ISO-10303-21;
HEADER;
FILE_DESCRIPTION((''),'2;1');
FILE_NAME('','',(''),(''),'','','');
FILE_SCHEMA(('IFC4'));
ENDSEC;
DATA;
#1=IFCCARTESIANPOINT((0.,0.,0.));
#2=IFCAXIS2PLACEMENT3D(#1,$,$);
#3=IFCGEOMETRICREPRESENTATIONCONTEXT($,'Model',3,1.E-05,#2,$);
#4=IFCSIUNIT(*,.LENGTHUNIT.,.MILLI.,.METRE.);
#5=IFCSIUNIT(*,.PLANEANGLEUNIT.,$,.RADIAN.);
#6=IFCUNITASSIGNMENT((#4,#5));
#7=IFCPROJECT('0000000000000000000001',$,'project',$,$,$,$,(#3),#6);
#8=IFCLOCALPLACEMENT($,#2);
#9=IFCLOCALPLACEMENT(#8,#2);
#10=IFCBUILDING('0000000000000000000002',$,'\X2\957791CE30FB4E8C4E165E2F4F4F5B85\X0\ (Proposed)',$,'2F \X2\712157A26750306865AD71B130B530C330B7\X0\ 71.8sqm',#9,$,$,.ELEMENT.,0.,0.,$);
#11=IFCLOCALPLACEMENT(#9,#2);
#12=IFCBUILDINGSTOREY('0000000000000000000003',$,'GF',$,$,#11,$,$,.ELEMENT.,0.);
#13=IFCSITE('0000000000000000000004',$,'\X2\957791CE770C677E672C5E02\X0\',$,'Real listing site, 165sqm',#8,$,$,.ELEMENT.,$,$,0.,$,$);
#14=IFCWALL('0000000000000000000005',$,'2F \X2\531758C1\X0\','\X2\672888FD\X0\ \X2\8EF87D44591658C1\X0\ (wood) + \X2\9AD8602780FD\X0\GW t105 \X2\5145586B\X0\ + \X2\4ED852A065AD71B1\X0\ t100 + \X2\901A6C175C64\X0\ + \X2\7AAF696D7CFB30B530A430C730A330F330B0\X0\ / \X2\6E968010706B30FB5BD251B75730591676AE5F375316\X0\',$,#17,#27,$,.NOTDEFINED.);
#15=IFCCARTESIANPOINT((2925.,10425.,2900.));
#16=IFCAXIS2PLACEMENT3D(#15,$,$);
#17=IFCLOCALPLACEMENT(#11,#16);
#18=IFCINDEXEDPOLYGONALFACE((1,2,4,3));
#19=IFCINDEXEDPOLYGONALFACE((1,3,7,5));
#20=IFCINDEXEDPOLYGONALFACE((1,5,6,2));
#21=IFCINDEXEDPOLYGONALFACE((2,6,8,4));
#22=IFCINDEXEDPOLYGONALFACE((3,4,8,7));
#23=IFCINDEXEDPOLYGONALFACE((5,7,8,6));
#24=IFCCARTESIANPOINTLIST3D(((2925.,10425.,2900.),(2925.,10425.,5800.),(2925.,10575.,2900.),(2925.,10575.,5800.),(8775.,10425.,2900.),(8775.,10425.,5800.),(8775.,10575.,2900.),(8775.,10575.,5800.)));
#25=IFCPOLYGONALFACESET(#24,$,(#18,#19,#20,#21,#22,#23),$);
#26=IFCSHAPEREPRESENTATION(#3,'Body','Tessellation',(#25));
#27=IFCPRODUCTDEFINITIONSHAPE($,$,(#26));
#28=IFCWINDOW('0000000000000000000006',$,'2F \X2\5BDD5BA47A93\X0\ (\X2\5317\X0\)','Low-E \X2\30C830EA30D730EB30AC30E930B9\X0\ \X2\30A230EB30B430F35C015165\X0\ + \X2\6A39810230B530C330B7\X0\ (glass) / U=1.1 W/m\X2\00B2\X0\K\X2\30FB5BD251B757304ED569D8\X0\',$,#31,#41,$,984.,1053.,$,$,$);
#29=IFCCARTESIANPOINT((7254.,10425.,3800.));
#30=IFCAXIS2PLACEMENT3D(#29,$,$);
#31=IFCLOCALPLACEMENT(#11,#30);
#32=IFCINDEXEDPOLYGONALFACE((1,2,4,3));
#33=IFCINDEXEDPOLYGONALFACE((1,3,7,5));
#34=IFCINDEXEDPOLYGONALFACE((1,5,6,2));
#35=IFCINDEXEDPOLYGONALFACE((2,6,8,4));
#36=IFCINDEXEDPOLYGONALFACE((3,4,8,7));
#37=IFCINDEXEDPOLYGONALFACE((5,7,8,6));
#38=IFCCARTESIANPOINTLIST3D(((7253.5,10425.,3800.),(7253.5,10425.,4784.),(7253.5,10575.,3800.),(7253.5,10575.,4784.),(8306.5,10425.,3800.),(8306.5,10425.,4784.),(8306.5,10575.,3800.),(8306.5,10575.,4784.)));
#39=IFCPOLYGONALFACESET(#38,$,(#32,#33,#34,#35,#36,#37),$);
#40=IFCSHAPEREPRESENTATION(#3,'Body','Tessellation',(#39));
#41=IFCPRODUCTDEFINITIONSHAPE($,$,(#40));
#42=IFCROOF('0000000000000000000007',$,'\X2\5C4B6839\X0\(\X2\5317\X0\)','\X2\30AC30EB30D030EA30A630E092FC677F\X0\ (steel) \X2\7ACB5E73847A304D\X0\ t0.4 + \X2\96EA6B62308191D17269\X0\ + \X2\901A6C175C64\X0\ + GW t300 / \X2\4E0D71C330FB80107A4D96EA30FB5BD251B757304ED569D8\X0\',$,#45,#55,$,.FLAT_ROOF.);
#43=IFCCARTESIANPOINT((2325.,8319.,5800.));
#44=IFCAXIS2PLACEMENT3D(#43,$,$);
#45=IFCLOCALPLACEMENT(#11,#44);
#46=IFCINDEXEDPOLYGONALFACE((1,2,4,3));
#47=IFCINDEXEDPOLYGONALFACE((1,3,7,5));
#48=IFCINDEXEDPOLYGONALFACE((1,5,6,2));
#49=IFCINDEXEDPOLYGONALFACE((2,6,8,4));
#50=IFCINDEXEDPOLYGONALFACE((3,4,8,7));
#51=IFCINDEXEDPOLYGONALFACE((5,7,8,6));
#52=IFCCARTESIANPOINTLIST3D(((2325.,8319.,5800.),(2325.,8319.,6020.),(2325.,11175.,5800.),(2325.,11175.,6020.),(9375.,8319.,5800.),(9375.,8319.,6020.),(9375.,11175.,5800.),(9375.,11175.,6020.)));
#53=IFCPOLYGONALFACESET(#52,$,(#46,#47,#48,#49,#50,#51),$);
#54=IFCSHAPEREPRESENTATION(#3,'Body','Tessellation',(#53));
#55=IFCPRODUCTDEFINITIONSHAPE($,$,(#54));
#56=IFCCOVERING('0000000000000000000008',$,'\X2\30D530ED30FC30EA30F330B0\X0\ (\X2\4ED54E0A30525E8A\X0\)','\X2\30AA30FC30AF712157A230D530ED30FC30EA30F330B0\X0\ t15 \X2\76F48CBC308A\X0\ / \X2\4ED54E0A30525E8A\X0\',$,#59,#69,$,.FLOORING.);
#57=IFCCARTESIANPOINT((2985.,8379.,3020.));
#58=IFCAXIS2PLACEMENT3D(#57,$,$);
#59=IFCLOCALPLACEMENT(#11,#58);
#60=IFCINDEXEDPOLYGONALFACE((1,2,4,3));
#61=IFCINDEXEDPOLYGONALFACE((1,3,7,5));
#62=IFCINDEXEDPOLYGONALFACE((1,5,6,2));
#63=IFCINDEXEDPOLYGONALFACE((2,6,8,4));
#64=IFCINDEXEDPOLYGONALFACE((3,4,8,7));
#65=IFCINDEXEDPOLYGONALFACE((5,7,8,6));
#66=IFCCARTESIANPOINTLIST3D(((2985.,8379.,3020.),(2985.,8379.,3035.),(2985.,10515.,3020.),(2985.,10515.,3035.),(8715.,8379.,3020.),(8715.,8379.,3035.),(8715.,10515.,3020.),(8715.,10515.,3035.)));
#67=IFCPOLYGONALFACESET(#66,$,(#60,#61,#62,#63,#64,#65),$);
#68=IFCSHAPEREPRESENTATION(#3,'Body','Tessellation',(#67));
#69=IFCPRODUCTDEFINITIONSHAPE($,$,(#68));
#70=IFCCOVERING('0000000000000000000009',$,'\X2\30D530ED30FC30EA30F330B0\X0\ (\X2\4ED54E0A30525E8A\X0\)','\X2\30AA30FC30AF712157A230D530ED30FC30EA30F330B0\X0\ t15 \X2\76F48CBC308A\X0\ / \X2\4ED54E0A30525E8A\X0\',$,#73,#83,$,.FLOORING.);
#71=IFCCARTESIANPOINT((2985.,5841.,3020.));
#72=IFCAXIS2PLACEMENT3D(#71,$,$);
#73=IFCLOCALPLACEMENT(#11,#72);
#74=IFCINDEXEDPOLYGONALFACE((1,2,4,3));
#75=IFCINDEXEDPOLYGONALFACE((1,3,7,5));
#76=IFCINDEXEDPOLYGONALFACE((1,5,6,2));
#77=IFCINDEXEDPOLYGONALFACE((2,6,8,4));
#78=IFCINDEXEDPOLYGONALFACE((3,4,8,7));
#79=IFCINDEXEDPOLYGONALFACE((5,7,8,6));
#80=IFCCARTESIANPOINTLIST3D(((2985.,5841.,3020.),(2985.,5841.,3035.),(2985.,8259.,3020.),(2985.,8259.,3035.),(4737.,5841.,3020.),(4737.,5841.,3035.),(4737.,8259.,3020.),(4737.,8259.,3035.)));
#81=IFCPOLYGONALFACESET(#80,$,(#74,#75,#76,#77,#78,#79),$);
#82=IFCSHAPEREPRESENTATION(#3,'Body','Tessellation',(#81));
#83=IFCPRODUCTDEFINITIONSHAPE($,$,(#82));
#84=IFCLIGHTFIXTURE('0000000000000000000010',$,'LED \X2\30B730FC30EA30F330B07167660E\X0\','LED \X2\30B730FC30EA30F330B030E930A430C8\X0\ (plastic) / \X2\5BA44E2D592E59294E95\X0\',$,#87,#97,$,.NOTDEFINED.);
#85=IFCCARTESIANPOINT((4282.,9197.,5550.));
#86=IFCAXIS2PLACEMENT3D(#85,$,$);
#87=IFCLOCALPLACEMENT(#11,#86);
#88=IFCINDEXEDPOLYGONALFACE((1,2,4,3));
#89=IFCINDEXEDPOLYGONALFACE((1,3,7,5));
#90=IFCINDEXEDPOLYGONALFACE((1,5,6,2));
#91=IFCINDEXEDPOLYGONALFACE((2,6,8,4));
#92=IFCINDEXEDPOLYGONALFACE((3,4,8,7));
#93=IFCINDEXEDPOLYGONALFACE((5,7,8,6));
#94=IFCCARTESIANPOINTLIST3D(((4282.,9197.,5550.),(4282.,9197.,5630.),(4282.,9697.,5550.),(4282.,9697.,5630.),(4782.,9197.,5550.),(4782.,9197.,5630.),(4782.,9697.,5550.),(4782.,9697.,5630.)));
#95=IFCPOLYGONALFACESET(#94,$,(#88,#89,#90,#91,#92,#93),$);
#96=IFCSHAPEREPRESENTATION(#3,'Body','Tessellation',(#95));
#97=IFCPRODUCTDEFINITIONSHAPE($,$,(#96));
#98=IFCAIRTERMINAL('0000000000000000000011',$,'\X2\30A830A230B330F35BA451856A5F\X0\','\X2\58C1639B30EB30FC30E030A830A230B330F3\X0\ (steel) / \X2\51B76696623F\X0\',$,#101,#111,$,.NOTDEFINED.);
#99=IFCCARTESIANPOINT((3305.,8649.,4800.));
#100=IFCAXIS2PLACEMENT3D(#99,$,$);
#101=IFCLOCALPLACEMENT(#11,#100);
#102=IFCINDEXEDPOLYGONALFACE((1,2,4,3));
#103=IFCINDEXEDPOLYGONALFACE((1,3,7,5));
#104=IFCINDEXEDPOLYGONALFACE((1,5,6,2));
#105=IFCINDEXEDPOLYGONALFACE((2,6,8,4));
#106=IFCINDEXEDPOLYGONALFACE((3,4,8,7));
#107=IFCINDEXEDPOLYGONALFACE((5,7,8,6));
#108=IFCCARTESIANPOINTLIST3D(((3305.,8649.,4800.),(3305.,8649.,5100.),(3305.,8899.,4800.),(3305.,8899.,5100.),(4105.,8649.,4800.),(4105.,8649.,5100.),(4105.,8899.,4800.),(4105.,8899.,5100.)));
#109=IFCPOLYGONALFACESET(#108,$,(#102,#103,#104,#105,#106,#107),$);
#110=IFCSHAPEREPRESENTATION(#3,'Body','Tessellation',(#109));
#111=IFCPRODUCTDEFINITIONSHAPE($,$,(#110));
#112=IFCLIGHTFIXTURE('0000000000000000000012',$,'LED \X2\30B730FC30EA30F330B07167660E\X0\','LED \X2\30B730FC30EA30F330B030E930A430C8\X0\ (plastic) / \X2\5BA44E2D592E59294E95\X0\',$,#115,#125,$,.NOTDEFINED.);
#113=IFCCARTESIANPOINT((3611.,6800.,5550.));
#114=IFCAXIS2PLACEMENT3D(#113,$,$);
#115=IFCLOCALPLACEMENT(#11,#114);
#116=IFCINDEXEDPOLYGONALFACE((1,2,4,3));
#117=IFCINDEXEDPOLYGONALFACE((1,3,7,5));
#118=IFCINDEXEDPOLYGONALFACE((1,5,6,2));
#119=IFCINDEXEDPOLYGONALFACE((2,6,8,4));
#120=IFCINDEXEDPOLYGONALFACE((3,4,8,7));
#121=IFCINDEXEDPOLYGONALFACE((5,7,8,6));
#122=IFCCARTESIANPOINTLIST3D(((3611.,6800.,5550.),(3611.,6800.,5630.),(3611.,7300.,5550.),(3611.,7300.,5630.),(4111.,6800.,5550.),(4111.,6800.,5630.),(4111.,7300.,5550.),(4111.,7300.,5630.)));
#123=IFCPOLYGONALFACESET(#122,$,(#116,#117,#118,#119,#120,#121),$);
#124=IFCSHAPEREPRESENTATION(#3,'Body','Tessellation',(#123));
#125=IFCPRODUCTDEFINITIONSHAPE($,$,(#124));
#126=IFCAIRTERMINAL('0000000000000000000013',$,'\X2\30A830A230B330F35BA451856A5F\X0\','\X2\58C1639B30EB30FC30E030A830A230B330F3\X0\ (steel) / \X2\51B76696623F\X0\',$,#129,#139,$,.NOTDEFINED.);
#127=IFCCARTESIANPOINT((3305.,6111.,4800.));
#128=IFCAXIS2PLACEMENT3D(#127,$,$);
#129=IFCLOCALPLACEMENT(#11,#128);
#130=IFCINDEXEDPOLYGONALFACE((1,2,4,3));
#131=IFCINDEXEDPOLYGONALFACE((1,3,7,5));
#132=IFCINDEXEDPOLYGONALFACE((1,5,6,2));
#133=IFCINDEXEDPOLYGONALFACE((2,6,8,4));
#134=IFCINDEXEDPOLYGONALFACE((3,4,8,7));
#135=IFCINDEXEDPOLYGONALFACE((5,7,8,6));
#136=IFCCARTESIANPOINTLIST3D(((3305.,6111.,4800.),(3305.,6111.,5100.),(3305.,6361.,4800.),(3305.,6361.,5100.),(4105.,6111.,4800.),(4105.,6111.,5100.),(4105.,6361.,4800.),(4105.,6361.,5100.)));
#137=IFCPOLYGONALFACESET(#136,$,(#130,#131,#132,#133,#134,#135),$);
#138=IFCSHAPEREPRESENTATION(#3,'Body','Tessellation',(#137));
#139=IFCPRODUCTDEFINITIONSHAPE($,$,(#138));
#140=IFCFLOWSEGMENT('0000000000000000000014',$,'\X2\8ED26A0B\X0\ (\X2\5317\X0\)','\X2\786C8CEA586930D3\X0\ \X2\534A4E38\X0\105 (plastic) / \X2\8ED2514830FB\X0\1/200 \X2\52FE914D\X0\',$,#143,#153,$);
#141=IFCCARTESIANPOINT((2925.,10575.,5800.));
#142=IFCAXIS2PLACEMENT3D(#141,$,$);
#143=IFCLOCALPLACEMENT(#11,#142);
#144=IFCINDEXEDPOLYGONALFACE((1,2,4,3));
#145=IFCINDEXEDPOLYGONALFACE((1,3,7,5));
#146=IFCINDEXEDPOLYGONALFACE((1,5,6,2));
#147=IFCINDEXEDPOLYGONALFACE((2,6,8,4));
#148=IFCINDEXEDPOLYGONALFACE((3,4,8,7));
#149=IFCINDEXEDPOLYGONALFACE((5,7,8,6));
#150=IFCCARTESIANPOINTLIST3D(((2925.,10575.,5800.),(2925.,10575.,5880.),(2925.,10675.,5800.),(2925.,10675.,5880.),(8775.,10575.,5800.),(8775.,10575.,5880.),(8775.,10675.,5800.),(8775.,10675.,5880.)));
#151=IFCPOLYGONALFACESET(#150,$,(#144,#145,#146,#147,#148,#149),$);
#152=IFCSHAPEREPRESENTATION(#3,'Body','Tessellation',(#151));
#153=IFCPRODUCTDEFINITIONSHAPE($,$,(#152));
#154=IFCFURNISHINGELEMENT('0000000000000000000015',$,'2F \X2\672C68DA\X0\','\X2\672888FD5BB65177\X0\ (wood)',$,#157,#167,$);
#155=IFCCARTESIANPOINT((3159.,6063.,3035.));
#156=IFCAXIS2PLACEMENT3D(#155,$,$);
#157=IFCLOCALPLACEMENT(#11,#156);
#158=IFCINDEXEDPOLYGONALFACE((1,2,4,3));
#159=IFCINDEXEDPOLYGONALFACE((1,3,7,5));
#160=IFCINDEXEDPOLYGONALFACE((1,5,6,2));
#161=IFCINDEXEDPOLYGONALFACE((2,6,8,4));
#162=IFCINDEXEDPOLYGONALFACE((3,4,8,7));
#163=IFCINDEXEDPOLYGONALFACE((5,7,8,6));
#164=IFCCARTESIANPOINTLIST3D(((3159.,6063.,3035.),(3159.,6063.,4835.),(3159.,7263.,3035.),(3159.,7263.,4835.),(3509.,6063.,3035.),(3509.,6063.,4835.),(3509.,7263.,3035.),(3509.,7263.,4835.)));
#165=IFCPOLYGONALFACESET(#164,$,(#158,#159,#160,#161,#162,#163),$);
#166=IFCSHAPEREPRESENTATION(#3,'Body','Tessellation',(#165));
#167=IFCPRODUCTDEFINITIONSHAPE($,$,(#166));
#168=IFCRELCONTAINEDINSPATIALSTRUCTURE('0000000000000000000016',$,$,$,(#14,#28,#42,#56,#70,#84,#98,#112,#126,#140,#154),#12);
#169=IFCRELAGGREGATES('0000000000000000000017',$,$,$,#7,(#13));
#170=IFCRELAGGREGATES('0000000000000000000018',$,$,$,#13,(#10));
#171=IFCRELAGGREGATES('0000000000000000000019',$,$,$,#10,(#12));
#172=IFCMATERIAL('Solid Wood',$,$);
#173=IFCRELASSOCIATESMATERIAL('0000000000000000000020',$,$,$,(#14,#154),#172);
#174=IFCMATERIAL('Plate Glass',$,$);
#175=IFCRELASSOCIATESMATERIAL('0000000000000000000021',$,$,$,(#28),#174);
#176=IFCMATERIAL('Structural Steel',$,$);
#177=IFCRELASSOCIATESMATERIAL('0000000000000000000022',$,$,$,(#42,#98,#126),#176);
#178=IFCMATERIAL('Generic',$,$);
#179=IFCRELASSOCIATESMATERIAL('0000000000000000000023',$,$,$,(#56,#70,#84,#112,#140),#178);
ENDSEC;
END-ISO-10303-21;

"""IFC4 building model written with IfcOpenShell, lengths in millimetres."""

from ifc_helpers import new_model, si_unit, frame, frame_2d, origin, place, context, project, spatial, rectangle, extrude, material, element, fill, save


model = new_model("IFC4")

# Units and contexts
model_context = context("Model", 3, precision=1e-05, world=origin())
ifc_project = project(units=[si_unit("LENGTHUNIT", "METRE", prefix="MILLI"), si_unit("PLANEANGLEUNIT", "RADIAN")], contexts=[model_context])

# Site, building, storey
site_placement = place(None, origin())
site = spatial("IfcSite", under=ifc_project, at=site_placement, Name="長野県松本市", ObjectType="Real listing site, 165sqm", CompositionType="ELEMENT", RefElevation=0.0)
building_placement = place(site_placement, origin())
building = spatial("IfcBuilding", under=site, at=building_placement, Name="長野・二世帯住宅 (Proposed)", ObjectType="2F 無垢材と断熱サッシ 71.8sqm", CompositionType="ELEMENT", ElevationOfRefHeight=0.0, ElevationOfTerrain=0.0)
storey_placement = place(building_placement, origin())
storey = spatial("IfcBuildingStorey", under=building, at=storey_placement, Name="GF", CompositionType="ELEMENT", Elevation=0.0)

# Shared definitions
ifc_material_1 = material(Name="Solid Wood")

# Wall, opening, window
wall_placement = place(storey_placement, frame((2925.0, 10425.0, 2900.0)))
wall = element("IfcWall", 1, at=wall_placement, inside=storey, material=ifc_material_1, Name="2F 北壁", Description="木製 軸組外壁 (wood) + 高性能GW t105 充填 + 付加断熱 t100 + 通気層 + 窯業系サイディング / 準耐火・寒冷地外皮強化", PredefinedType="NOTDEFINED", context=model_context, shape_type="SweptSolid", body=[
    extrude(rectangle(XDim=5850.0, YDim=150.0, at=frame_2d((2925.0, 75.0))), frame((2925.0, 10425.0, 2900.0)), (0.0, 0.0, 1.0), 2900.0),
])
opening_placement = place(storey_placement, frame((7254.0, 10425.0, 3800.0)))
opening = element("IfcOpeningElement", 2, at=opening_placement, cuts=wall, PredefinedType="NOTDEFINED", context=model_context, shape_type="SweptSolid", body=[
    extrude(rectangle(XDim=1053.0, YDim=150.0, at=frame_2d((526.0, 75.0))), frame((7254.0, 10425.0, 3800.0)), (0.0, 0.0, 1.0), 984.0),
])
ifc_material_2 = material(Name="Plate Glass")
window_placement = place(storey_placement, frame((7254.0, 10425.0, 3800.0)))
window = element("IfcWindow", 3, at=window_placement, inside=storey, material=ifc_material_2, Name="2F 寝室窓 (北)", Description="Low-E トリプルガラス アルゴン封入 + 樹脂サッシ (glass) / U=1.1 W/m²K・寒冷地仕様", OverallHeight=984.0, OverallWidth=1053.0, context=model_context, shape_type="SweptSolid", body=[
    extrude(rectangle(XDim=1053.0, YDim=150.0, at=frame_2d((526.0, 75.0))), frame((7254.0, 10425.0, 3800.0)), (0.0, 0.0, 1.0), 984.0),
])
fill(opening, window)

# Roof
ifc_material_3 = material(Name="Structural Steel")
for number, where, name in (
    (4, (2325.0, 8319.0, 5800.0), "屋根(北)"),
):
    element("IfcRoof", number, at=place(storey_placement, frame(where)), inside=storey, material=ifc_material_3, Name=name, Description="ガルバリウム鋼板 (steel) 立平葺き t0.4 + 雪止め金物 + 通気層 + GW t300 / 不燃・耐積雪・寒冷地仕様", PredefinedType="FLAT_ROOF", context=model_context, shape_type="SweptSolid", body=[
        extrude(rectangle(XDim=7050.0, YDim=2856.0, at=frame_2d((3525.0, 1428.0))), frame((2325.0, 8319.0, 5800.0)), (0.0, 0.0, 1.0), 220.0),
    ])

# Coverings
ifc_material_4 = material(Name="Generic")
covering_1_placement = place(storey_placement, frame((2985.0, 8379.0, 3020.0)))
element("IfcCovering", 5, at=covering_1_placement, inside=storey, material=ifc_material_4, Name="フローリング (仕上げ床)", Description="オーク無垢フローリング t15 直貼り / 仕上げ床", PredefinedType="FLOORING", context=model_context, shape_type="SweptSolid", body=[
    extrude(rectangle(XDim=5730.0, YDim=2136.0, at=frame_2d((2865.0, 1068.0))), frame((2985.0, 8379.0, 3020.0)), (0.0, 0.0, 1.0), 15.0),
])
covering_2_placement = place(storey_placement, frame((2985.0, 5841.0, 3020.0)))
element("IfcCovering", 6, at=covering_2_placement, inside=storey, material=ifc_material_4, Name="フローリング (仕上げ床)", Description="オーク無垢フローリング t15 直貼り / 仕上げ床", PredefinedType="FLOORING", context=model_context, shape_type="SweptSolid", body=[
    extrude(rectangle(XDim=1752.0, YDim=2418.0, at=frame_2d((876.0, 1209.0))), frame((2985.0, 5841.0, 3020.0)), (0.0, 0.0, 1.0), 15.0),
])

# Light fixture
light_fixture_1_placement = place(storey_placement, frame((4282.0, 9197.0, 5550.0)))
element("IfcLightFixture", 7, at=light_fixture_1_placement, inside=storey, material=ifc_material_4, Name="LED シーリング照明", Description="LED シーリングライト (plastic) / 室中央天井", PredefinedType="NOTDEFINED", context=model_context, shape_type="SweptSolid", body=[
    extrude(rectangle(XDim=500.0, YDim=500.0, at=frame_2d((250.0, 250.0))), frame((4282.0, 9197.0, 5550.0)), (0.0, 0.0, 1.0), 80.0),
])

# Air terminal
air_terminal_1_placement = place(storey_placement, frame((3305.0, 8649.0, 4800.0)))
element("IfcAirTerminal", 8, at=air_terminal_1_placement, inside=storey, material=ifc_material_3, Name="エアコン室内機", Description="壁掛ルームエアコン (steel) / 冷暖房", PredefinedType="NOTDEFINED", context=model_context, shape_type="SweptSolid", body=[
    extrude(rectangle(XDim=800.0, YDim=250.0, at=frame_2d((400.0, 125.0))), frame((3305.0, 8649.0, 4800.0)), (0.0, 0.0, 1.0), 300.0),
])

# Light fixture
light_fixture_2_placement = place(storey_placement, frame((3611.0, 6800.0, 5550.0)))
element("IfcLightFixture", 9, at=light_fixture_2_placement, inside=storey, material=ifc_material_4, Name="LED シーリング照明", Description="LED シーリングライト (plastic) / 室中央天井", PredefinedType="NOTDEFINED", context=model_context, shape_type="SweptSolid", body=[
    extrude(rectangle(XDim=500.0, YDim=500.0, at=frame_2d((250.0, 250.0))), frame((3611.0, 6800.0, 5550.0)), (0.0, 0.0, 1.0), 80.0),
])

# Air terminal
air_terminal_2_placement = place(storey_placement, frame((3305.0, 6111.0, 4800.0)))
element("IfcAirTerminal", 10, at=air_terminal_2_placement, inside=storey, material=ifc_material_3, Name="エアコン室内機", Description="壁掛ルームエアコン (steel) / 冷暖房", PredefinedType="NOTDEFINED", context=model_context, shape_type="SweptSolid", body=[
    extrude(rectangle(XDim=800.0, YDim=250.0, at=frame_2d((400.0, 125.0))), frame((3305.0, 6111.0, 4800.0)), (0.0, 0.0, 1.0), 300.0),
])

# Flow segment
flow_segment_placement = place(storey_placement, frame((2925.0, 10575.0, 5800.0)))
element("IfcFlowSegment", 11, at=flow_segment_placement, inside=storey, material=ifc_material_4, Name="軒樋 (北)", Description="硬質塩ビ 半丸105 (plastic) / 軒先・1/200 勾配", context=model_context, shape_type="SweptSolid", body=[
    extrude(rectangle(XDim=5850.0, YDim=100.0, at=frame_2d((2925.0, 50.0))), frame((2925.0, 10575.0, 5800.0)), (0.0, 0.0, 1.0), 80.0),
])

# Furnishing element
furnishing_placement = place(storey_placement, frame((3159.0, 6063.0, 3035.0)))
element("IfcFurnishingElement", 12, at=furnishing_placement, inside=storey, material=ifc_material_1, Name="2F 本棚", Description="木製家具 (wood)", context=model_context, shape_type="SweptSolid", body=[
    extrude(rectangle(XDim=350.0, YDim=1200.0, at=frame_2d((175.0, 600.0))), frame((3159.0, 6063.0, 3035.0)), (0.0, 0.0, 1.0), 1800.0),
])

save(model, "model.ifc")
